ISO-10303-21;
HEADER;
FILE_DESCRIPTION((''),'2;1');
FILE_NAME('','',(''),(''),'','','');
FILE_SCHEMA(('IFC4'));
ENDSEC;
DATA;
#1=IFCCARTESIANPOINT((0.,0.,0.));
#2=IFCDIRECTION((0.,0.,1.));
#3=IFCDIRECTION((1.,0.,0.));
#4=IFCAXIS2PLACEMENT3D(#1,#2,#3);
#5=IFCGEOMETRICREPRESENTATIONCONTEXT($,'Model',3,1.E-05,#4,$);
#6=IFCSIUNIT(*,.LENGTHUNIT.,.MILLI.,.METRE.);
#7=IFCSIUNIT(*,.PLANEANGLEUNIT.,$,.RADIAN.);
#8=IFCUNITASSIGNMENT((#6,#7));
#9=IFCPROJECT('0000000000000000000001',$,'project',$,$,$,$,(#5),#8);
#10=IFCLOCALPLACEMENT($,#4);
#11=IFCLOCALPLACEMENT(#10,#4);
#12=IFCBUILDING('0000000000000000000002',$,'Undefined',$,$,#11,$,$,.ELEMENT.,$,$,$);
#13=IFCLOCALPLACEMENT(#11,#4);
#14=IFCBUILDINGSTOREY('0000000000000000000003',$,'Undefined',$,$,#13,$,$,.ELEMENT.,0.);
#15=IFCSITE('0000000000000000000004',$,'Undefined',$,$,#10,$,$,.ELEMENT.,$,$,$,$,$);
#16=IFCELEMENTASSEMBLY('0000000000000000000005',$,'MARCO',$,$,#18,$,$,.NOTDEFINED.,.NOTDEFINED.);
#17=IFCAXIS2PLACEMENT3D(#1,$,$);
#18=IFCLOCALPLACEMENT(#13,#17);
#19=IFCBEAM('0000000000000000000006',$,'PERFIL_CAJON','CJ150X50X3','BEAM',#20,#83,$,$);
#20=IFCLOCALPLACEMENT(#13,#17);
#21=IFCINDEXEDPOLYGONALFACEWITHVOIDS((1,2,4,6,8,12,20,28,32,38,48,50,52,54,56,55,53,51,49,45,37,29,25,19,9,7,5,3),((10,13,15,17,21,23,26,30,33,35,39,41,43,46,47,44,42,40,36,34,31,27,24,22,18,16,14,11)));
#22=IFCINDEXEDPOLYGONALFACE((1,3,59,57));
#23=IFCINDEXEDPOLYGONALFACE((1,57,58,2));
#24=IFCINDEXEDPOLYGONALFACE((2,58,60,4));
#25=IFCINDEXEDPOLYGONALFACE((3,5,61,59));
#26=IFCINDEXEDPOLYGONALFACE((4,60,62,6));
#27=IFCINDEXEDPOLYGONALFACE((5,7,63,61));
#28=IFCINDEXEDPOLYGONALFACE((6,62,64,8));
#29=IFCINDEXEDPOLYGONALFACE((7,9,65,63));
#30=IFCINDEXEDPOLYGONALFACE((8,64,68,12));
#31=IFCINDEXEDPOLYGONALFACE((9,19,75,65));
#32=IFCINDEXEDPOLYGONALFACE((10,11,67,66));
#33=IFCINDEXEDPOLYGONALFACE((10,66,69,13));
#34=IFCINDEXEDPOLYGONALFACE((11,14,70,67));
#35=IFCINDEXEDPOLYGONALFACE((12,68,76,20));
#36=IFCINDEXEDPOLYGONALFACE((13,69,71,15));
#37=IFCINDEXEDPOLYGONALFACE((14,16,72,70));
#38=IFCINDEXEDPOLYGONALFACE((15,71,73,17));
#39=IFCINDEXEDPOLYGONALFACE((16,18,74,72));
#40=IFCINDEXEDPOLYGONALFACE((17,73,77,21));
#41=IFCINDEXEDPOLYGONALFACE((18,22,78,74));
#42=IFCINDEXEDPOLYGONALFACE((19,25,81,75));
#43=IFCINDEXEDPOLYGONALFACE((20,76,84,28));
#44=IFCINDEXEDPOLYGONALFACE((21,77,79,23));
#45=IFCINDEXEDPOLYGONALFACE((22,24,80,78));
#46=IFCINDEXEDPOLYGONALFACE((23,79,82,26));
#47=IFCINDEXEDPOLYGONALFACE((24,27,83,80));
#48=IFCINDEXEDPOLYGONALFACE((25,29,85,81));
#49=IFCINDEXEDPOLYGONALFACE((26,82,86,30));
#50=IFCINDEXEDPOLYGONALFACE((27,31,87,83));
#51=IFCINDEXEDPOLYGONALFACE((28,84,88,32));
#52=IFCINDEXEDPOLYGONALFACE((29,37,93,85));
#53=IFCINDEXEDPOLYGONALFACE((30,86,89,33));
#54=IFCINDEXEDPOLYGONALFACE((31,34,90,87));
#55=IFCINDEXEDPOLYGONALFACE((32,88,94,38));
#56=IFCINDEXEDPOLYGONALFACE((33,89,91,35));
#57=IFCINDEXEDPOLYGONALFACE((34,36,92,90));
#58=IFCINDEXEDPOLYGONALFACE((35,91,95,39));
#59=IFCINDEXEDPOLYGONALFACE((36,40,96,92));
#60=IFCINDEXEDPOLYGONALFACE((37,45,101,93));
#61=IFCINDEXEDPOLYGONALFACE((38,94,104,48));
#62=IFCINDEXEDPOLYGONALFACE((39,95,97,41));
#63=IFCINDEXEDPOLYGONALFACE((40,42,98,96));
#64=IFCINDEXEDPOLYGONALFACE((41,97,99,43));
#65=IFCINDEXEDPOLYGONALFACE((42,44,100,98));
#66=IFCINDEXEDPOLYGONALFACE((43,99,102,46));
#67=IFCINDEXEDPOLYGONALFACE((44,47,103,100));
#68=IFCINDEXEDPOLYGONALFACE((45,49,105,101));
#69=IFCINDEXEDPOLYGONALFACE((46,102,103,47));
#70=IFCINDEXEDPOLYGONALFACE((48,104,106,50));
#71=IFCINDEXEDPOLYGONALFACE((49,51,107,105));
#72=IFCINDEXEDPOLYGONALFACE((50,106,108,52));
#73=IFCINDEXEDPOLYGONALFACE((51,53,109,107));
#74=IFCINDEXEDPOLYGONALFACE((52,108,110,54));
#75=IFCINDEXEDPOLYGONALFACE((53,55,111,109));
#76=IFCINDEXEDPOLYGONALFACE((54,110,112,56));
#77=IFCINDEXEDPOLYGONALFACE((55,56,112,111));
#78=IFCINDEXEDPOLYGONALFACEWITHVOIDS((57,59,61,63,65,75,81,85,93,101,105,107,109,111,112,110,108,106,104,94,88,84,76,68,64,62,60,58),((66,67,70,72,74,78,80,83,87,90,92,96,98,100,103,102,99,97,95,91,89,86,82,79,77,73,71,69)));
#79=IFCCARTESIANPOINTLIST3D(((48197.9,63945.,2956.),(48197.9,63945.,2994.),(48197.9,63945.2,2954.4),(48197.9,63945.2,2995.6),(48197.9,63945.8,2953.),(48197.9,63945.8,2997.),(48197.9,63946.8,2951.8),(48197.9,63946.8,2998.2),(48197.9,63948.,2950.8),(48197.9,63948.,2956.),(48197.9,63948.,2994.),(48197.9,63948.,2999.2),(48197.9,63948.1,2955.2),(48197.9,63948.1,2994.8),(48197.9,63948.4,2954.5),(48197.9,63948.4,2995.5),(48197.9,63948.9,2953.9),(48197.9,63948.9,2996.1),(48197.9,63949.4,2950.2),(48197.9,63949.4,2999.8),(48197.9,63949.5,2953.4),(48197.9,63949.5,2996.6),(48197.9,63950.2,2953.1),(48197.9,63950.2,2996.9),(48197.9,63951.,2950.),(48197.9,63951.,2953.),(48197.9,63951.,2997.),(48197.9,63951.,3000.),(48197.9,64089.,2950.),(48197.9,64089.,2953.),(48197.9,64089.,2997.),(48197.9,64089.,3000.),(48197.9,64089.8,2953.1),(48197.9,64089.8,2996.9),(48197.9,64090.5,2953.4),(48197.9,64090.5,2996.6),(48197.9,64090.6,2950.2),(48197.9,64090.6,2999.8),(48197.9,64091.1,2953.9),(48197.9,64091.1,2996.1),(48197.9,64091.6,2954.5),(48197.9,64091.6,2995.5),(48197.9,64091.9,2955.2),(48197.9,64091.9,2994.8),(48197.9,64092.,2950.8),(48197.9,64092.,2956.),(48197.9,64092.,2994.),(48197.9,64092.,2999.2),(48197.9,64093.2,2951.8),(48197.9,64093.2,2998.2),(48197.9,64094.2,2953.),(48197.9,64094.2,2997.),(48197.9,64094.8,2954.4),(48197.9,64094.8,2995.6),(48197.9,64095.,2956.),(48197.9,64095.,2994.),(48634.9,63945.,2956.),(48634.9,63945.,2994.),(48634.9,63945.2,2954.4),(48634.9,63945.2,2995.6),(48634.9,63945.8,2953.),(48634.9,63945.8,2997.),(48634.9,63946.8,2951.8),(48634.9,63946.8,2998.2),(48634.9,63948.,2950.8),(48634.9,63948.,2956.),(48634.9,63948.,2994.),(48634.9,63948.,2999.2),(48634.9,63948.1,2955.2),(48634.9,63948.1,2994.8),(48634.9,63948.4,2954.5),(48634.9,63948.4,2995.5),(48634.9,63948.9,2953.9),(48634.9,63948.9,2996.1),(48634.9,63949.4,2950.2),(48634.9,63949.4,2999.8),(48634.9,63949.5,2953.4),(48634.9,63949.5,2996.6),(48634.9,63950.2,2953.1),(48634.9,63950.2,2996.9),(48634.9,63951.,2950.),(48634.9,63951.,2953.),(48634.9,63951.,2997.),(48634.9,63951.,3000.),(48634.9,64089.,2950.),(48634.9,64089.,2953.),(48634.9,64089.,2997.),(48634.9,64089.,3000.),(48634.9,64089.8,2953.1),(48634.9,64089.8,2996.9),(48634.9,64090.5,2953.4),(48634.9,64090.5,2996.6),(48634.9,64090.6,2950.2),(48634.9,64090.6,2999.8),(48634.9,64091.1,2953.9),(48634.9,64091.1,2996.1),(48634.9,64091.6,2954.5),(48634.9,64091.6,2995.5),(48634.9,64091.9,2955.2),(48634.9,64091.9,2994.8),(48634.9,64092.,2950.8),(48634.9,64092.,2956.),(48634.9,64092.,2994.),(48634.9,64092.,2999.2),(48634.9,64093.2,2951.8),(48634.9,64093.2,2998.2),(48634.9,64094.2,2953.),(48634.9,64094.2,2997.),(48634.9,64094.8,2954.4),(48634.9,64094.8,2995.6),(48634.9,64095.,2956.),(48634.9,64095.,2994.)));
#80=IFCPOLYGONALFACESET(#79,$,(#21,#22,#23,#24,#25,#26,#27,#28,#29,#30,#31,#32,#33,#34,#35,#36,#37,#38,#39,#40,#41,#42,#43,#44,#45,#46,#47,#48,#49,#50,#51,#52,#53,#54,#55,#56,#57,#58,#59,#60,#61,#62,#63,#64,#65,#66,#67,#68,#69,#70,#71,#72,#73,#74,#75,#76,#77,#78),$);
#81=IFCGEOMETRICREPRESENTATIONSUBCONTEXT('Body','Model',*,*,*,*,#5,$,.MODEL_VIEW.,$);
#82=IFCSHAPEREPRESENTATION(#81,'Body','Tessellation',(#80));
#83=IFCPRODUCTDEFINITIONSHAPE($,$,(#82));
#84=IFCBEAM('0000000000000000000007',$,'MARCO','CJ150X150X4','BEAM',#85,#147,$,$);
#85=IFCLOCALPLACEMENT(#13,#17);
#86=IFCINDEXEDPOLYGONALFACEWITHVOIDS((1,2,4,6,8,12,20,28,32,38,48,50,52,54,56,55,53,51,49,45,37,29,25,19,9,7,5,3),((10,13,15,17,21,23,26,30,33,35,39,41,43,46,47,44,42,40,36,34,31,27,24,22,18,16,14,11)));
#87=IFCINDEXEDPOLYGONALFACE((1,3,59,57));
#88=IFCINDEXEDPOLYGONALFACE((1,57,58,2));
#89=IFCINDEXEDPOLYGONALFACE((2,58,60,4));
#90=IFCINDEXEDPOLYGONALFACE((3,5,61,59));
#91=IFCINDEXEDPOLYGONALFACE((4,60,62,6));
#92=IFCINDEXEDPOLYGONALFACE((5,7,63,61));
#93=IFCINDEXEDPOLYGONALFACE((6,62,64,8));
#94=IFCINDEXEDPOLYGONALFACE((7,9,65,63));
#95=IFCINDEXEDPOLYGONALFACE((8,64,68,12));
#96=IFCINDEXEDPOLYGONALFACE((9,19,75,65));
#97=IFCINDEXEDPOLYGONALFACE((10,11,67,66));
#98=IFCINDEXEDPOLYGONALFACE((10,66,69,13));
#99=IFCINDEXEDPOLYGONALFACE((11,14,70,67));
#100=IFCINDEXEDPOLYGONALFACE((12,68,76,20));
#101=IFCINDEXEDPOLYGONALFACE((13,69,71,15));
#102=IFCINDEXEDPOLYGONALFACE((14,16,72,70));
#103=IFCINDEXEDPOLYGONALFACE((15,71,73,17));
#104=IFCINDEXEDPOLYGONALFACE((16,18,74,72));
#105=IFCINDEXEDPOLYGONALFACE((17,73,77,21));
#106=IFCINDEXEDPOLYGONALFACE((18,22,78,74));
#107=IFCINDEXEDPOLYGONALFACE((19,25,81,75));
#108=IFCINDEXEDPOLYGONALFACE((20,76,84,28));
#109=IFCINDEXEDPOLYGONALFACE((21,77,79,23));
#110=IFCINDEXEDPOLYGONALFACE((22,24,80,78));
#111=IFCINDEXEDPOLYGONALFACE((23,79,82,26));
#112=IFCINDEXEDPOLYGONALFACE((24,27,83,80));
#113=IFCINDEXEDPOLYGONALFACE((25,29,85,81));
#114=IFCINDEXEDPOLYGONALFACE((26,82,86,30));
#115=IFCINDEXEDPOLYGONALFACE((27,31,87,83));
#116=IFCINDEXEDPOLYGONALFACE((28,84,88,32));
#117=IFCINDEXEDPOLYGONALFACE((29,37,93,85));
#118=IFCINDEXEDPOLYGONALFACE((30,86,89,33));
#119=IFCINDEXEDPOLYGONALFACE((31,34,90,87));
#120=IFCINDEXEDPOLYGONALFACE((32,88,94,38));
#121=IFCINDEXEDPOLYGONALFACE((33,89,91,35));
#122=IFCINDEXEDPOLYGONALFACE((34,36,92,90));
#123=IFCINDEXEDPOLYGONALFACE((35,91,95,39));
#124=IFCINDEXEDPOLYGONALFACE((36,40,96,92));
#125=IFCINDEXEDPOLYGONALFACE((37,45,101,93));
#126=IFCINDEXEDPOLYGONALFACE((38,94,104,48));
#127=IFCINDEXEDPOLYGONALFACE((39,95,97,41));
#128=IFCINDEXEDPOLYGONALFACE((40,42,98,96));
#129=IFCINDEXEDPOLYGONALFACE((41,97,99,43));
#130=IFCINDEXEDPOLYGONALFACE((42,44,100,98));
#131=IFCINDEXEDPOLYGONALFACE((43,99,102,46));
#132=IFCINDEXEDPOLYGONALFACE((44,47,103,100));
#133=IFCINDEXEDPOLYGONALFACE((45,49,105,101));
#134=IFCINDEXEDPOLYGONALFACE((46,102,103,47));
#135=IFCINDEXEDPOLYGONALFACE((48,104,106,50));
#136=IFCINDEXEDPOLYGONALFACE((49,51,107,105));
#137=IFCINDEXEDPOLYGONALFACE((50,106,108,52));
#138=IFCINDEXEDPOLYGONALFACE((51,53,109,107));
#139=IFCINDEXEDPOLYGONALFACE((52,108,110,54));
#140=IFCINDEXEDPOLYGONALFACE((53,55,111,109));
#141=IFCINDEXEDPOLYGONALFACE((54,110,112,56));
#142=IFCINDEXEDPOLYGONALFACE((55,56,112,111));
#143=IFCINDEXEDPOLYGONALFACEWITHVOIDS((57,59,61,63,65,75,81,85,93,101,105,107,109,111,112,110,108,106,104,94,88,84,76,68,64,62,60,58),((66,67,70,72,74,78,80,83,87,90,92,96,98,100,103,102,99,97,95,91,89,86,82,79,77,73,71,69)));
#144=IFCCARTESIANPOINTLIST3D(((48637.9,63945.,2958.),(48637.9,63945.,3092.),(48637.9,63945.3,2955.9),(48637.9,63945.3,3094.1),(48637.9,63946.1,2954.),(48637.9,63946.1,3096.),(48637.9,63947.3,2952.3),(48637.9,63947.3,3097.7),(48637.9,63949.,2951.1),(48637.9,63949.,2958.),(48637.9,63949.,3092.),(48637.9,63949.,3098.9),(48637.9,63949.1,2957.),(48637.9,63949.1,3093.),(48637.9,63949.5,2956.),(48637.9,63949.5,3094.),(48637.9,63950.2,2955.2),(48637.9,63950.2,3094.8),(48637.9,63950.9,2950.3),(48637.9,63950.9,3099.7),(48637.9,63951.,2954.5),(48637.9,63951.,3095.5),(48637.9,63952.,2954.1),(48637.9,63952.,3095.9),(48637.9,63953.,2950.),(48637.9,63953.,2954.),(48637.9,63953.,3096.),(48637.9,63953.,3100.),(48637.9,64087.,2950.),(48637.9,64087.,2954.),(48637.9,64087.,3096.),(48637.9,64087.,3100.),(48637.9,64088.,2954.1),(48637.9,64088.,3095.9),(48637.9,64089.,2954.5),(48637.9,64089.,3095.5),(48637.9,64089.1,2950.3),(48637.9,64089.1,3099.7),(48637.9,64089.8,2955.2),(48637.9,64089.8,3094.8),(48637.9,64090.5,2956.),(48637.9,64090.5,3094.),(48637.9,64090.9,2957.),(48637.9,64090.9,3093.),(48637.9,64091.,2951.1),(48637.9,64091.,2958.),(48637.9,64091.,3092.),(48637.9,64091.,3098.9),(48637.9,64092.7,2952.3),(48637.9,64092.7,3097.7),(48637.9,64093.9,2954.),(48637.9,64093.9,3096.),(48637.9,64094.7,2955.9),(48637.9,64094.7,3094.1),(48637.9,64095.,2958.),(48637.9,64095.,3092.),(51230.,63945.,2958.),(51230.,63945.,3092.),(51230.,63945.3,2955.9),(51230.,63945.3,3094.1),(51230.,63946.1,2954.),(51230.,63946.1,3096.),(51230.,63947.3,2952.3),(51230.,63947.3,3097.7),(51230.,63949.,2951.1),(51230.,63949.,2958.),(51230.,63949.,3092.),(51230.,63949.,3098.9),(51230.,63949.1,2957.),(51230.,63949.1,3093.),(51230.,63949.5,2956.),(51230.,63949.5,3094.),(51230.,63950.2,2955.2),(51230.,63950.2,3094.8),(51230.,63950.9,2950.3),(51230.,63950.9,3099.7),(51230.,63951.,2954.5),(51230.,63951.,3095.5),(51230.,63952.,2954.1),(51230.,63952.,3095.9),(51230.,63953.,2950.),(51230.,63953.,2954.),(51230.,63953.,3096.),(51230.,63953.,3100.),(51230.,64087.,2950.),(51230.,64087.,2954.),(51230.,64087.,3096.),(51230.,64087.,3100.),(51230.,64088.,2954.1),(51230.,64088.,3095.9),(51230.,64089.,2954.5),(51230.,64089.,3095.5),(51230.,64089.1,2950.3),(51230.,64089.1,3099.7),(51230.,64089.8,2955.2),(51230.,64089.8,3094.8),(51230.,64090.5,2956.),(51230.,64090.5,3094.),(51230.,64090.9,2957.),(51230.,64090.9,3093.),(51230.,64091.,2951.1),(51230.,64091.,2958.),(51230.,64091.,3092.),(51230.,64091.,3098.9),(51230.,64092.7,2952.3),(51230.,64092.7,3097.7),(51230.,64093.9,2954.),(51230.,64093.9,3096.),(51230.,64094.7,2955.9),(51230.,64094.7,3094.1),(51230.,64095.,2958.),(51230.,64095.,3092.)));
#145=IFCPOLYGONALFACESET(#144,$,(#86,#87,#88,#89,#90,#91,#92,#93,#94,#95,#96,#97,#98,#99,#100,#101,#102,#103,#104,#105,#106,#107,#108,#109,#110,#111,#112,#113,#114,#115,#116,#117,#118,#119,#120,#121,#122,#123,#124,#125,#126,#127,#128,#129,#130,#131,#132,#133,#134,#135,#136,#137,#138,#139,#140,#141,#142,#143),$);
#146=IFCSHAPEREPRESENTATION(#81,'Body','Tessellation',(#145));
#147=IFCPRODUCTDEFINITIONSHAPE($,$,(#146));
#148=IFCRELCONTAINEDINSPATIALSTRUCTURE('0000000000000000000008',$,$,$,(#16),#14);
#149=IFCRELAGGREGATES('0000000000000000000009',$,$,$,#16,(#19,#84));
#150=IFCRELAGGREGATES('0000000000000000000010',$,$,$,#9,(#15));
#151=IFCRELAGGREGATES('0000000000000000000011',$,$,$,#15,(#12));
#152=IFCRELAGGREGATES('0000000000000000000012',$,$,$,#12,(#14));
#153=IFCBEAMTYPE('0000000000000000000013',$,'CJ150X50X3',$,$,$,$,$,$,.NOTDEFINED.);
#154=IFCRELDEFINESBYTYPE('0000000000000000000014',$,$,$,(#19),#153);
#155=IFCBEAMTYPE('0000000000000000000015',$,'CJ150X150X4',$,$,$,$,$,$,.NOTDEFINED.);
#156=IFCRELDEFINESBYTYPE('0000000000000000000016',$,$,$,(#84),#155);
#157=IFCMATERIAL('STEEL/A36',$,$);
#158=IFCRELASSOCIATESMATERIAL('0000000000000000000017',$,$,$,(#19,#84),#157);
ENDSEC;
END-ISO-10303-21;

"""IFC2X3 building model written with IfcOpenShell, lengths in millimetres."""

from ifc_helpers import new_model, si_unit, frame, origin_with_axes, origin_2d_with_axis, place, context, subcontext, project, spatial, hollow_rectangle, extrude, material, type_object, element, aggregate, save


model = new_model("IFC2X3")

# Units and contexts
model_context = context("Model", 3, precision=1e-05, world=origin_with_axes())
body_context = subcontext(model_context, "Body", "Model", "MODEL_VIEW")
ifc_project = project(units=[si_unit("LENGTHUNIT", "METRE", prefix="MILLI"), si_unit("PLANEANGLEUNIT", "RADIAN")], contexts=[model_context])

# Site, building, storey
site_placement = place(None, origin_with_axes())
site = spatial("IfcSite", under=ifc_project, at=site_placement, Name="Undefined", CompositionType="ELEMENT")
building_placement = place(site_placement, origin_with_axes())
building = spatial("IfcBuilding", under=site, at=building_placement, Name="Undefined", CompositionType="ELEMENT")
storey_placement = place(building_placement, origin_with_axes())
storey = spatial("IfcBuildingStorey", under=building, at=storey_placement, Name="Undefined", CompositionType="ELEMENT", Elevation=0.0)

# Element assembly, beams
assembly_1_placement = place(storey_placement, origin_with_axes())
assembly_1 = element("IfcElementAssembly", 1, at=assembly_1_placement, inside=storey, Name="MARCO", AssemblyPlace="NOTDEFINED", PredefinedType="NOTDEFINED")
ifc_material_1 = material(Name="STEEL/A36")
beam_type_1 = type_object("IfcBeamType", Name="CJ150X50X3", PredefinedType="NOTDEFINED")
beam_1_placement = place(assembly_1_placement, frame((48197.9, 64020.0, 2975.0), z_axis=(0.0, 1.0, 0.0), x_axis=(1.0, 0.0, 0.0)))
beam_1 = element("IfcBeam", 2, at=beam_1_placement, type_object=beam_type_1, material=ifc_material_1, Name="PERFIL_CAJON", Description="CJ150X50X3", ObjectType="BEAM", context=body_context, shape_type="SweptSolid", body=[
    extrude(hollow_rectangle(XDim=50.0, YDim=150.0, WallThickness=3.0, InnerFilletRadius=3.0, OuterFilletRadius=6.0, at=origin_2d_with_axis()), frame((437.0, 0.0, 0.0), z_axis=(-1.0, 0.0, 0.0), x_axis=(0.0, -1.0, 0.0)), (0.0, 0.0, 1.0), 437.0),
])
beam_type_2 = type_object("IfcBeamType", Name="CJ150X150X4", PredefinedType="NOTDEFINED")
beam_2_placement = place(assembly_1_placement, frame((48637.9, 64020.0, 3025.0), z_axis=(0.0, 0.0, 1.0), x_axis=(1.0, 0.0, 0.0)))
beam_2 = element("IfcBeam", 3, at=beam_2_placement, type_object=beam_type_2, material=ifc_material_1, Name="MARCO", Description="CJ150X150X4", ObjectType="BEAM", context=body_context, shape_type="SweptSolid", body=[
    extrude(hollow_rectangle(XDim=150.0, YDim=150.0, WallThickness=4.0, InnerFilletRadius=4.0, OuterFilletRadius=8.0, at=origin_2d_with_axis()), frame((2592.1, 0.0, 0.0), z_axis=(-1.0, 0.0, 0.0), x_axis=(0.0, -1.0, 0.0)), (0.0, 0.0, 1.0), 2592.1),
])

aggregate(assembly_1, [beam_1, beam_2])

save(model, "model.ifc")
